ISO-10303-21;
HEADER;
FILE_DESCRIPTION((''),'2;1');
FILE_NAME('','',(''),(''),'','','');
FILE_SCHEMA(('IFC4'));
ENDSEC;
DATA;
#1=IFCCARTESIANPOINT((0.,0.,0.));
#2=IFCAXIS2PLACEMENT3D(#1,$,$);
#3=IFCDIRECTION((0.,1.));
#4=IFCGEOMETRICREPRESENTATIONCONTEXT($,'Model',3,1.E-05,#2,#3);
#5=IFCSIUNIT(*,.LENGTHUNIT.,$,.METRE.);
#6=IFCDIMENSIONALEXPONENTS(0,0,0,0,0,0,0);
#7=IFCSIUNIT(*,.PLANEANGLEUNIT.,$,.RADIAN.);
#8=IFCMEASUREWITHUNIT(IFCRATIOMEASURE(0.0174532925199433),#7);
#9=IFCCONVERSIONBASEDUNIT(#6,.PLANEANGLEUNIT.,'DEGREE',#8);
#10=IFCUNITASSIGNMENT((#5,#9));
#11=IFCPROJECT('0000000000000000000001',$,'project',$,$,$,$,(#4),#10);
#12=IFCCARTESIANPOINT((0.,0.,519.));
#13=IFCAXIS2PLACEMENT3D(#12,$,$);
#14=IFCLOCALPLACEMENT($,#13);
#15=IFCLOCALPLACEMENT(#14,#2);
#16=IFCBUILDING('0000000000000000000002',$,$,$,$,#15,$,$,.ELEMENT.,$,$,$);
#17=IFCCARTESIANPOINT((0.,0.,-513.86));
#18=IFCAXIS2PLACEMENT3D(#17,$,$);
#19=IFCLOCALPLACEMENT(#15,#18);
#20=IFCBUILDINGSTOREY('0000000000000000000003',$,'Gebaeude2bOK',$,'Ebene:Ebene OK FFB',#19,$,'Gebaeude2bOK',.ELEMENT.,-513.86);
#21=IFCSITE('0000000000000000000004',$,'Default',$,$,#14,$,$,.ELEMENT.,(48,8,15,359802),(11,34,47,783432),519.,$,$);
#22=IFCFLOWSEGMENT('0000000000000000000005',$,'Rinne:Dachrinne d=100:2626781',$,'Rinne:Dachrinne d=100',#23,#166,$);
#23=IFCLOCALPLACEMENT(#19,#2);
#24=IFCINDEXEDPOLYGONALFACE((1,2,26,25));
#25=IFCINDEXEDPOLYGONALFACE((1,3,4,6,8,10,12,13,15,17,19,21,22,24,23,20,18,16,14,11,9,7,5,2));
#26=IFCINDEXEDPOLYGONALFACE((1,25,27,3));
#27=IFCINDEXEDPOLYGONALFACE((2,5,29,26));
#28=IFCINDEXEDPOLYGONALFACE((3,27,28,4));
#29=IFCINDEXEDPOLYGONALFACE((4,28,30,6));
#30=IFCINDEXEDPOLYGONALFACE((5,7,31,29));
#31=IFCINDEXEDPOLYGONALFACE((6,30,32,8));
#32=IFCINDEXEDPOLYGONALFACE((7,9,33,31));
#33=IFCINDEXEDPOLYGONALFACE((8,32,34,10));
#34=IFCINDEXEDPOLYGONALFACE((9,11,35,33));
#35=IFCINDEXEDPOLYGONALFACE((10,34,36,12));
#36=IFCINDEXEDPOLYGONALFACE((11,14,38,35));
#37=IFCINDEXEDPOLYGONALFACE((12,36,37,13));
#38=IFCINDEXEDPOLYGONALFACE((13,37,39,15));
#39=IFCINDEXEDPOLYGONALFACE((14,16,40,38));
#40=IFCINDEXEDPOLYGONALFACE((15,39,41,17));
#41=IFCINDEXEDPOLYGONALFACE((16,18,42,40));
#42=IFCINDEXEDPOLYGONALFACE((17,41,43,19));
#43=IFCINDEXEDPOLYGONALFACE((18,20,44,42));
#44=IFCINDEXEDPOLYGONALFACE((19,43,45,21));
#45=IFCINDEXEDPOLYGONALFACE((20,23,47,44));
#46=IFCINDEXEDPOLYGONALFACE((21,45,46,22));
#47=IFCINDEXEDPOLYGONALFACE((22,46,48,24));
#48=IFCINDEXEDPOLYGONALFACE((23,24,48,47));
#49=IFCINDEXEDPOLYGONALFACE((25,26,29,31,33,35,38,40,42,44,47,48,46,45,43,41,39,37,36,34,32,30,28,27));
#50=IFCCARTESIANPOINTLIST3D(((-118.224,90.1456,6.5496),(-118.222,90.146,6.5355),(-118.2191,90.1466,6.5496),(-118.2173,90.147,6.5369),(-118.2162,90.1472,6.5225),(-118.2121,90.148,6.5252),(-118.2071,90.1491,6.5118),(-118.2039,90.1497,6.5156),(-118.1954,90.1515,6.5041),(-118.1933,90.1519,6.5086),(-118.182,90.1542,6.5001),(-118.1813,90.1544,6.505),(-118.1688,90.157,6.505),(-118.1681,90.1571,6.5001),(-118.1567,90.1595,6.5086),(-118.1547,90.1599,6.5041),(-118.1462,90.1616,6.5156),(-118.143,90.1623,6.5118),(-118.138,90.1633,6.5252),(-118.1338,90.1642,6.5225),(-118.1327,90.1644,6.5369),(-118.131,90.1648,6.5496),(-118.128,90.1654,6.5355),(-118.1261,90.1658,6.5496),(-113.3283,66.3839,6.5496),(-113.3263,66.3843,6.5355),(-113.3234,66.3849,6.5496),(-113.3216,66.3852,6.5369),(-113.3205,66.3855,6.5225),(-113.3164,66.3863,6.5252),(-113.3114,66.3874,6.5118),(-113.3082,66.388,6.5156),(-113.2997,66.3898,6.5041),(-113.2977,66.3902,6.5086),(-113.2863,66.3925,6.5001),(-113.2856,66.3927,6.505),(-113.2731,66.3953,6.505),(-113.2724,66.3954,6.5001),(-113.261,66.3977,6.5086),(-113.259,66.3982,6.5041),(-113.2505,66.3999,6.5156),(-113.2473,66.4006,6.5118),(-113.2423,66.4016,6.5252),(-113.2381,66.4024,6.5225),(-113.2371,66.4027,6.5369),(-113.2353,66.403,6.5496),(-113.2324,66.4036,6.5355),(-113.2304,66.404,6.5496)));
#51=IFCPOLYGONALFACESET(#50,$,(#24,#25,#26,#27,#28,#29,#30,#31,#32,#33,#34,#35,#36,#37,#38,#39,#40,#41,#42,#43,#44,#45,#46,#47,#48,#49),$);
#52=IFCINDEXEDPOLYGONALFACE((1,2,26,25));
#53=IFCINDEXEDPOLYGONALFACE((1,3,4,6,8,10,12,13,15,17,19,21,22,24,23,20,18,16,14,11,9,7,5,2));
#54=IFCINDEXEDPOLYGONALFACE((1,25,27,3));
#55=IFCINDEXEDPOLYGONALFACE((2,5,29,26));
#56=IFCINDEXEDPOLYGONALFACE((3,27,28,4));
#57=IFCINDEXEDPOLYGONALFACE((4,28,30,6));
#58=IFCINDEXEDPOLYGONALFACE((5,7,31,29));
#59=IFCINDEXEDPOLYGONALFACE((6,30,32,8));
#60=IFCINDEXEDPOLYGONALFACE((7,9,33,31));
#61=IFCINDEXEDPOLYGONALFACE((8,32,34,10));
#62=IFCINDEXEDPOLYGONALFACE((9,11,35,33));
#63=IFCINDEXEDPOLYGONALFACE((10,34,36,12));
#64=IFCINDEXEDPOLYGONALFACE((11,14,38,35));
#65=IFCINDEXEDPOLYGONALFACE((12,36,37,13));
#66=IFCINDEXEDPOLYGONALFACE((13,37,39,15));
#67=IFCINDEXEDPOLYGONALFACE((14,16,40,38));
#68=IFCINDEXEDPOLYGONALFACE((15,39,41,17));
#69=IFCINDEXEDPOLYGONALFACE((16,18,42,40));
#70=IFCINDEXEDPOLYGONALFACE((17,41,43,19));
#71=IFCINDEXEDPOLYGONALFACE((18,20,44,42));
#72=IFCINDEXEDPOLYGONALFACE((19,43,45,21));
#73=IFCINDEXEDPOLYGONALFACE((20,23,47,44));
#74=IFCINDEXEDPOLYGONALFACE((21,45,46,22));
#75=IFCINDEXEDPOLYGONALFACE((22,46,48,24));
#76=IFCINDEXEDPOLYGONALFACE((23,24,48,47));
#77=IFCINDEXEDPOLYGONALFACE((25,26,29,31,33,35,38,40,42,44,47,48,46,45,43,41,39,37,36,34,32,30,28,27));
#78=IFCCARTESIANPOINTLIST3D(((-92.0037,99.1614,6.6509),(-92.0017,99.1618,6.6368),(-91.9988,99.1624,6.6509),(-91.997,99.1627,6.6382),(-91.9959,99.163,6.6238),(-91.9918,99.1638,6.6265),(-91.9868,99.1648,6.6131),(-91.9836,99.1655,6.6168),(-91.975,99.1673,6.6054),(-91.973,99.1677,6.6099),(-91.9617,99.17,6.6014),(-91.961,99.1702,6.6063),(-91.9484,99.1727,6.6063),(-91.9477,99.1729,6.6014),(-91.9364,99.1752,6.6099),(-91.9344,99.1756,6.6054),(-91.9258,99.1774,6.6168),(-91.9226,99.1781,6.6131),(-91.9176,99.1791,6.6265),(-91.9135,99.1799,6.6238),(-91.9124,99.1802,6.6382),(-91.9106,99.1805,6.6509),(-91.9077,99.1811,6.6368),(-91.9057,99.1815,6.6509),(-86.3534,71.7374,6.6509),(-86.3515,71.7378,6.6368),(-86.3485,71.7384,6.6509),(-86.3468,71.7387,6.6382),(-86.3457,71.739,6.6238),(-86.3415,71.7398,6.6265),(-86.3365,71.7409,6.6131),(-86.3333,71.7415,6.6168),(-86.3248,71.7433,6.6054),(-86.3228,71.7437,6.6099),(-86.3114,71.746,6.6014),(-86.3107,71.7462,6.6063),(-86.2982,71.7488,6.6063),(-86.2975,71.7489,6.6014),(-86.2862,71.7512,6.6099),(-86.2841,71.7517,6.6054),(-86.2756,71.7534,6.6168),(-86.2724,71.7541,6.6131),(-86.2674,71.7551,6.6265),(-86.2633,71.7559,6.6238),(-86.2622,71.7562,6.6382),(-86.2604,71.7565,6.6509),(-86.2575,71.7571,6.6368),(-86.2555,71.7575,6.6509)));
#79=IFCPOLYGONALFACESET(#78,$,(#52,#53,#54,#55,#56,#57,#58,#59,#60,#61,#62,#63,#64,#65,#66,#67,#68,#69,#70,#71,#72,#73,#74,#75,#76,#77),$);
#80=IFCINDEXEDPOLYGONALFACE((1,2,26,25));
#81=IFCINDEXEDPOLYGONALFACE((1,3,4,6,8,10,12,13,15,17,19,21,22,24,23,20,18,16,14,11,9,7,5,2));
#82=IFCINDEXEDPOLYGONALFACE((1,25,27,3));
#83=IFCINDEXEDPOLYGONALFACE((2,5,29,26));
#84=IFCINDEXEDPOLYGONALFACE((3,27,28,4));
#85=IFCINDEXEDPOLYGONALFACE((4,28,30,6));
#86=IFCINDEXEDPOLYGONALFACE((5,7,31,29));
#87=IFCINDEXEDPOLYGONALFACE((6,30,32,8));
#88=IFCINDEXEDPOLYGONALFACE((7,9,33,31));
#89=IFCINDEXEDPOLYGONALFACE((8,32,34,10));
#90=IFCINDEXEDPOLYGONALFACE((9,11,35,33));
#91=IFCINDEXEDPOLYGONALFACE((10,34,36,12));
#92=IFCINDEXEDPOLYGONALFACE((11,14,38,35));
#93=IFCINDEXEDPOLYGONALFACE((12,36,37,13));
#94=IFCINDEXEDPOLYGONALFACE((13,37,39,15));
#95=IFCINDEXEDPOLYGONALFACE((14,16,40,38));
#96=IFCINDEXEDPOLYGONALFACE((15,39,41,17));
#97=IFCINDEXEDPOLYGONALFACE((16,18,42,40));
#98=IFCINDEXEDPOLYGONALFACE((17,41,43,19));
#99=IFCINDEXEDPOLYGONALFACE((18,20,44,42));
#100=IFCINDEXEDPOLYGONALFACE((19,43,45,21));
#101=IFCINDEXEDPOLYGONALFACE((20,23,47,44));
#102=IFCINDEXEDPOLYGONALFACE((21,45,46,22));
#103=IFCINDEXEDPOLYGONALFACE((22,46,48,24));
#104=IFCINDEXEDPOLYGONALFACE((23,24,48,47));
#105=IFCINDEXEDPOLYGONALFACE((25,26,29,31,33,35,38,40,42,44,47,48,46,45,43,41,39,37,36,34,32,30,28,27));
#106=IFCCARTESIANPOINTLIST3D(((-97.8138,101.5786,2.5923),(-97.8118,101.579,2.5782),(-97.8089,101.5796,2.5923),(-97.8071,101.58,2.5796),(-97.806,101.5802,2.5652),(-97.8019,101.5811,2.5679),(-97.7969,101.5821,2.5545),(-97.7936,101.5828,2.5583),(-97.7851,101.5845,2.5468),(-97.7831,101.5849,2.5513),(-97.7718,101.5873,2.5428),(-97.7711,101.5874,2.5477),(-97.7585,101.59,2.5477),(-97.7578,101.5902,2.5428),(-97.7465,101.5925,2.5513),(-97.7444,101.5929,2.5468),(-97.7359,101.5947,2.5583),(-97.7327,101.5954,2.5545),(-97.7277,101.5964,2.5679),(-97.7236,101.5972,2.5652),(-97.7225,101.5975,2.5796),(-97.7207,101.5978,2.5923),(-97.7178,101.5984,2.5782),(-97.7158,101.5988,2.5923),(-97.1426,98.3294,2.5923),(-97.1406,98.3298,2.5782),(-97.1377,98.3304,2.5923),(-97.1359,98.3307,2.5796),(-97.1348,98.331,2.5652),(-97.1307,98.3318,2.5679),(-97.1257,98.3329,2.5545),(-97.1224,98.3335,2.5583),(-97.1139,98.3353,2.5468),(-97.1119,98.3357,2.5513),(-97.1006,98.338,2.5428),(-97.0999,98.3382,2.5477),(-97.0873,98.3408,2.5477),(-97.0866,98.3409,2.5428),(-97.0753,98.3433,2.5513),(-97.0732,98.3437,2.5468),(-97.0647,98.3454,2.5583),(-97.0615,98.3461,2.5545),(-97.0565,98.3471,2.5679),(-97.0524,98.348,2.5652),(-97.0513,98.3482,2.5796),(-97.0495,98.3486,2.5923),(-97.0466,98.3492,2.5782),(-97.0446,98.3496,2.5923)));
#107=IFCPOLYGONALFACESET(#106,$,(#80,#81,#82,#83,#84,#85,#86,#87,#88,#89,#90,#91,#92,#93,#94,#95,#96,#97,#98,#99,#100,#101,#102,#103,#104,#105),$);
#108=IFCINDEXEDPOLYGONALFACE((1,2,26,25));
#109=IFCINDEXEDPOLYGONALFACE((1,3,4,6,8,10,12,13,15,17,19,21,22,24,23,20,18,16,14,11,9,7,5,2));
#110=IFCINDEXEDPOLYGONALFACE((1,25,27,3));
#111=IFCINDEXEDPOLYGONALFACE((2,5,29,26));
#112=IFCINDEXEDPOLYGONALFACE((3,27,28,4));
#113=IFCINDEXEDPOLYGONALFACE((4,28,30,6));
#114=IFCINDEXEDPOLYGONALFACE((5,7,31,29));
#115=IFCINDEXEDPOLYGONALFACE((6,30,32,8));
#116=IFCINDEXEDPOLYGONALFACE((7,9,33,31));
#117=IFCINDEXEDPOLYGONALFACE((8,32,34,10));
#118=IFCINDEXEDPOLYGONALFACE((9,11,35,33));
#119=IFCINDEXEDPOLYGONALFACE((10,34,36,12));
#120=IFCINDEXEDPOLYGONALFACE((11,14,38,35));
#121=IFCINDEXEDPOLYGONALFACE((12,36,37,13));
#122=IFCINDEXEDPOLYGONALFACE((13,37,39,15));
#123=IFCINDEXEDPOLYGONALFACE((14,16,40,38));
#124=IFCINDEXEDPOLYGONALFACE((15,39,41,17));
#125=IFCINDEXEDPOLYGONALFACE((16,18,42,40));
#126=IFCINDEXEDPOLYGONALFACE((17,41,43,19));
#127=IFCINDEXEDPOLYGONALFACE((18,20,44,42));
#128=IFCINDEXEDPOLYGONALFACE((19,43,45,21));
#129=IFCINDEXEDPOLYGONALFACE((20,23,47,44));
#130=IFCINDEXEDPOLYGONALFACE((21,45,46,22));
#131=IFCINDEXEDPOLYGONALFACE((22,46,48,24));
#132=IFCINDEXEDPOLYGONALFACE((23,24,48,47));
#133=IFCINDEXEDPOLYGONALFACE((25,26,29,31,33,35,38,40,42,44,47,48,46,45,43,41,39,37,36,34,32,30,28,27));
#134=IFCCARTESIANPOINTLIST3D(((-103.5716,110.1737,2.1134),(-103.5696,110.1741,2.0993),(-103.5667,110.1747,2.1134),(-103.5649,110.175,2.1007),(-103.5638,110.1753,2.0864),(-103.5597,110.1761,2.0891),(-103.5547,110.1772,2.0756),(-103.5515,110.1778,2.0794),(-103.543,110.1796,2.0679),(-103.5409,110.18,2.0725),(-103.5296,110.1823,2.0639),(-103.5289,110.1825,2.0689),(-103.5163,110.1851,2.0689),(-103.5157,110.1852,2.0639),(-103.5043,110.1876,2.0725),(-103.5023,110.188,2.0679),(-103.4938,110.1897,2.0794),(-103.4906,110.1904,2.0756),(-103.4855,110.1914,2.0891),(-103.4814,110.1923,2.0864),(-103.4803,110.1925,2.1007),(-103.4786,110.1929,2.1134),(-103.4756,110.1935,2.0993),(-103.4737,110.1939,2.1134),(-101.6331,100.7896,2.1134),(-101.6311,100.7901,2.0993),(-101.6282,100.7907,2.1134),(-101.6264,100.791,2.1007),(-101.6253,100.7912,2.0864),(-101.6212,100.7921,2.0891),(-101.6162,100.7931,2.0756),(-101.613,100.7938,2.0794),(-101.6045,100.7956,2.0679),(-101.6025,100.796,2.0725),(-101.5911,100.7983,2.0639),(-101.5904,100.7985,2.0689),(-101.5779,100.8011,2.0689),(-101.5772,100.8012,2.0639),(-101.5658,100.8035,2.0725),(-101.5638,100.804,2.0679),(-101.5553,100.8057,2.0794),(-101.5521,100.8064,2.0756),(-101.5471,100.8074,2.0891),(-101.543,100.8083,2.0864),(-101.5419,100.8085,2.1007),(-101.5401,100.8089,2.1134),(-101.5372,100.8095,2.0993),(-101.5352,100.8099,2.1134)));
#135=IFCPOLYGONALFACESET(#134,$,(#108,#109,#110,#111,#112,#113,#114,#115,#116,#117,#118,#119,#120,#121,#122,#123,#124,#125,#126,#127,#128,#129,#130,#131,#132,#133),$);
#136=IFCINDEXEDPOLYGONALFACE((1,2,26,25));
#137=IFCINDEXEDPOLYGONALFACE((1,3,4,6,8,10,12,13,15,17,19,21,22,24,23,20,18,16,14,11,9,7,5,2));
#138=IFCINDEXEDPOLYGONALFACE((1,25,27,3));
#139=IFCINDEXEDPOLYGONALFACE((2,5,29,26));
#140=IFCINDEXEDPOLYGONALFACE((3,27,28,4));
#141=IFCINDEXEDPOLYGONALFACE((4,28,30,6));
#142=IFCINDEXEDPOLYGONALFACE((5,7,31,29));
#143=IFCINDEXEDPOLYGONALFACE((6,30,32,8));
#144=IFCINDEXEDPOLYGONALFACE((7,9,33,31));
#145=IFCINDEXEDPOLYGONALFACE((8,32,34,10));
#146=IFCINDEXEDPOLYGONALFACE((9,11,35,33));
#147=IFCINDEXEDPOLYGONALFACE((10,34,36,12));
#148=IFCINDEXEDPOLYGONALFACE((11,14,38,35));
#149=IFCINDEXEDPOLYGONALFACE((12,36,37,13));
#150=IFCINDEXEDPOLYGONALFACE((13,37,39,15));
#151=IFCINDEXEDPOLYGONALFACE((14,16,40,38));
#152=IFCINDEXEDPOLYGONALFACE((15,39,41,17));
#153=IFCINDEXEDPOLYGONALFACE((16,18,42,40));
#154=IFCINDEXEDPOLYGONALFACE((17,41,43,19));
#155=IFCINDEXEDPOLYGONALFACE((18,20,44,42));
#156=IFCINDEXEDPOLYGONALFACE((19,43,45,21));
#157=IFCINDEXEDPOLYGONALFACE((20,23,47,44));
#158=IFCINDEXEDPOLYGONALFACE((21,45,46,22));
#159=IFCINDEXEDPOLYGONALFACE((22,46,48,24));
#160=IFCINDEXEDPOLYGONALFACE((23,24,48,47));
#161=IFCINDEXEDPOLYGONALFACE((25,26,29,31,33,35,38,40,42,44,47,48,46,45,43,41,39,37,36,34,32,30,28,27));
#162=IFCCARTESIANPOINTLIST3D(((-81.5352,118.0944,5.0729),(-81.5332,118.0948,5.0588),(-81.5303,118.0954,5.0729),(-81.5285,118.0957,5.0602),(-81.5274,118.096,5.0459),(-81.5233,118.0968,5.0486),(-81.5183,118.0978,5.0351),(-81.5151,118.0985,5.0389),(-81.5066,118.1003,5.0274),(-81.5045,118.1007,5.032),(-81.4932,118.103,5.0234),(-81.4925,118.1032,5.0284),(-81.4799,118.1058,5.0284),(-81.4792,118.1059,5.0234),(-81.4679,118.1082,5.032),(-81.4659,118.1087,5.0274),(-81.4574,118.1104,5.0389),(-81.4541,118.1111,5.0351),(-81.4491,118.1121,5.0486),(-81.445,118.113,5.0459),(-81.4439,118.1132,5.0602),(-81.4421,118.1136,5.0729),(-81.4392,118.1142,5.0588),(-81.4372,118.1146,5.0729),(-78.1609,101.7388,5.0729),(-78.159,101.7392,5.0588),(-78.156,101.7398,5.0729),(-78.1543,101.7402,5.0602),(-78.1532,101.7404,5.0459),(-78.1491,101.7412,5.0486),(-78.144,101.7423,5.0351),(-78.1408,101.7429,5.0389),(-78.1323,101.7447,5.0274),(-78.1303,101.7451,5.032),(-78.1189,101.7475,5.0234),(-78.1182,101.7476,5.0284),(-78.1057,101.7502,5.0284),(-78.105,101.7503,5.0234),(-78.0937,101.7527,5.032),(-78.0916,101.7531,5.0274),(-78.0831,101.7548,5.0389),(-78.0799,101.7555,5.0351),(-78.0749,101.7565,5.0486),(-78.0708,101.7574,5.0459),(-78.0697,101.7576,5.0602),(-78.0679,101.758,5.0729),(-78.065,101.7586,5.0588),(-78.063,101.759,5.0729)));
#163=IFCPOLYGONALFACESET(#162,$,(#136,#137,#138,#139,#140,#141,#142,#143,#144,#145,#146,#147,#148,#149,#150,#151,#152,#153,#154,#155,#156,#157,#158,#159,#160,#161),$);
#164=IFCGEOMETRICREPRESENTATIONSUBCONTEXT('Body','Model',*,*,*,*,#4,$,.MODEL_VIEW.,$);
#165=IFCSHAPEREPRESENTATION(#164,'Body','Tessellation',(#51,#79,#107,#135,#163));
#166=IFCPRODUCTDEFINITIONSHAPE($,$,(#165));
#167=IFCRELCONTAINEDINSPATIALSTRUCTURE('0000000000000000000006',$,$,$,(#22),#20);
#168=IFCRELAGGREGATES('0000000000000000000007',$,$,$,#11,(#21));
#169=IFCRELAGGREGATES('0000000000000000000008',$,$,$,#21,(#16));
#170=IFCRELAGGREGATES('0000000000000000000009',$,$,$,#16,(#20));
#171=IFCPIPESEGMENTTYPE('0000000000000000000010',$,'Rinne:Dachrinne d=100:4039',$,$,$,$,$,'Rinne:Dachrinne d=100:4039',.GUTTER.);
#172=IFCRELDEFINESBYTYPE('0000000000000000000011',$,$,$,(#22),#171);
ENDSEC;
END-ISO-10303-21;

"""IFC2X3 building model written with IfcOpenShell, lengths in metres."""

from ifc_helpers import new_model, entity, si_unit, converted_unit, direction, frame, frame_2d, origin, origin_2d_with_axis, place, context, subcontext, project, spatial, polyline, circle_curve, parameter, trimmed, segment, composite_curve, outline, extrude, source, transform, mapped, type_object, type_shapes, element, save


model = new_model("IFC2X3")

# Units and contexts
model_context = context("Model", 3, precision=1e-05, world=origin(), true_north=direction((0.0, 1.0)))
body_context = subcontext(model_context, "Body", "Model", "MODEL_VIEW")
ifc_project = project(units=[si_unit("LENGTHUNIT", "METRE"), converted_unit("PLANEANGLEUNIT", "DEGREE", entity("IfcRatioMeasure", 0.0174532925199433), si_unit("PLANEANGLEUNIT", "RADIAN"), dimensions=[0, 0, 0, 0, 0, 0, 0])], contexts=[model_context])

# Site, building, storey
site_placement = place(None, frame((0.0, 0.0, 519.0)))
site = spatial("IfcSite", under=ifc_project, at=site_placement, Name="Default", CompositionType="ELEMENT", RefLatitude=(48, 8, 15, 359802), RefLongitude=(11, 34, 47, 783432), RefElevation=519.0)
building_placement = place(site_placement, origin())
building = spatial("IfcBuilding", under=site, at=building_placement, CompositionType="ELEMENT")
storey_placement = place(building_placement, frame((0.0, 0.0, -513.86)))
storey = spatial("IfcBuildingStorey", under=building, at=storey_placement, Name="Gebaeude2bOK", ObjectType="Ebene:Ebene OK FFB", LongName="Gebaeude2bOK", CompositionType="ELEMENT", Elevation=-513.86)

# Flow segment
pipe_segment_type = type_object("IfcPipeSegmentType", Name="Rinne:Dachrinne d=100:4039", ElementType="Rinne:Dachrinne d=100:4039", PredefinedType="GUTTER")
shared_shape = source(origin(), body_context, "Body", "SweptSolid", [
    extrude(outline(composite_curve([segment(polyline([(-0.05, 0.0), (-0.045, 0.0)]), True, "CONTINUOUS"), segment(trimmed(circle_curve(frame_2d((0.0, 0.0), x_axis=(-1.0, 0.0)), 0.045), [parameter(180.0)], [parameter(0.0)], True, "PARAMETER"), False, "CONTINUOUS"), segment(polyline([(0.045, 0.0), (0.05, 0.0)]), True, "CONTINUOUS"), segment(trimmed(circle_curve(frame_2d((0.0, 0.0), x_axis=(-1.0, 0.0)), 0.05), [parameter(180.0)], [parameter(0.0)], True, "PARAMETER"), True, "CONTINUOUS")], self_intersect=False)), frame((-113.2793, 66.394, 6.5496), z_axis=(-0.201794, 0.979428, 0.0), x_axis=(0.979428, 0.201794, 0.0)), (0.0, 0.0, 1.0), 24.2608),
    extrude(outline(composite_curve([segment(trimmed(circle_curve(origin_2d_with_axis(), 0.05), [parameter(0.0)], [parameter(180.0)], True, "PARAMETER"), True, "CONTINUOUS"), segment(polyline([(-0.05, 0.0), (-0.045, 0.0)]), True, "CONTINUOUS"), segment(trimmed(circle_curve(origin_2d_with_axis(), 0.045), [parameter(0.0)], [parameter(180.0)], True, "PARAMETER"), False, "CONTINUOUS"), segment(polyline([(0.045, 0.0), (0.05, 0.0)]), True, "CONTINUOUS")], self_intersect=False)), frame((-86.3045, 71.7475, 6.6509), z_axis=(-0.201794, 0.979428, 0.0), x_axis=(0.979428, 0.201794, 0.0)), (0.0, 0.0, 1.0), 28.0),
    extrude(outline(composite_curve([segment(trimmed(circle_curve(origin_2d_with_axis(), 0.05), [parameter(0.0)], [parameter(180.0)], True, "PARAMETER"), True, "CONTINUOUS"), segment(polyline([(-0.05, 0.0), (-0.045, 0.0)]), True, "CONTINUOUS"), segment(trimmed(circle_curve(origin_2d_with_axis(), 0.045), [parameter(0.0)], [parameter(180.0)], True, "PARAMETER"), False, "CONTINUOUS"), segment(polyline([(0.045, 0.0), (0.05, 0.0)]), True, "CONTINUOUS")], self_intersect=False)), frame((-97.7648, 101.5887, 2.5923), z_axis=(0.2023, -0.979324, 0.0), x_axis=(-0.979324, -0.2023, 0.0)), (0.0, 0.0, 1.0), 3.3179),
    extrude(outline(composite_curve([segment(trimmed(circle_curve(origin_2d_with_axis(), 0.05), [parameter(0.0)], [parameter(180.0)], True, "PARAMETER"), True, "CONTINUOUS"), segment(polyline([(-0.05, 0.0), (-0.045, 0.0)]), True, "CONTINUOUS"), segment(trimmed(circle_curve(origin_2d_with_axis(), 0.045), [parameter(0.0)], [parameter(180.0)], True, "PARAMETER"), False, "CONTINUOUS"), segment(polyline([(0.045, 0.0), (0.05, 0.0)]), True, "CONTINUOUS")], self_intersect=False)), frame((-103.5226, 110.1838, 2.1134), z_axis=(0.2023, -0.979324, 0.0), x_axis=(-0.979324, -0.2023, 0.0)), (0.0, 0.0, 1.0), 9.5821),
    extrude(outline(composite_curve([segment(polyline([(-0.05, 0.0), (-0.045, 0.0)]), True, "CONTINUOUS"), segment(trimmed(circle_curve(frame_2d((0.0, 0.0), x_axis=(-1.0, 0.0)), 0.045), [parameter(180.0)], [parameter(0.0)], True, "PARAMETER"), False, "CONTINUOUS"), segment(polyline([(0.045, 0.0), (0.05, 0.0)]), True, "CONTINUOUS"), segment(trimmed(circle_curve(frame_2d((0.0, 0.0), x_axis=(-1.0, 0.0)), 0.05), [parameter(180.0)], [parameter(0.0)], True, "PARAMETER"), True, "CONTINUOUS")], self_intersect=False)), frame((-81.4862, 118.1045, 5.0729), z_axis=(0.20205, -0.979375, 0.0), x_axis=(-0.979375, -0.20205, 0.0)), (0.0, 0.0, 1.0), 16.7),
])
type_shapes(pipe_segment_type, [shared_shape])
flow_segment_placement = place(storey_placement, origin())
element("IfcFlowSegment", 1, at=flow_segment_placement, inside=storey, type_object=pipe_segment_type, Name="Rinne:Dachrinne d=100:2626781", ObjectType="Rinne:Dachrinne d=100", context=body_context, shape_type="MappedRepresentation", body=[
    mapped(shared_shape, transform((0.0, 0.0, 0.0), scale=1.0)),
])

save(model, "model.ifc")
